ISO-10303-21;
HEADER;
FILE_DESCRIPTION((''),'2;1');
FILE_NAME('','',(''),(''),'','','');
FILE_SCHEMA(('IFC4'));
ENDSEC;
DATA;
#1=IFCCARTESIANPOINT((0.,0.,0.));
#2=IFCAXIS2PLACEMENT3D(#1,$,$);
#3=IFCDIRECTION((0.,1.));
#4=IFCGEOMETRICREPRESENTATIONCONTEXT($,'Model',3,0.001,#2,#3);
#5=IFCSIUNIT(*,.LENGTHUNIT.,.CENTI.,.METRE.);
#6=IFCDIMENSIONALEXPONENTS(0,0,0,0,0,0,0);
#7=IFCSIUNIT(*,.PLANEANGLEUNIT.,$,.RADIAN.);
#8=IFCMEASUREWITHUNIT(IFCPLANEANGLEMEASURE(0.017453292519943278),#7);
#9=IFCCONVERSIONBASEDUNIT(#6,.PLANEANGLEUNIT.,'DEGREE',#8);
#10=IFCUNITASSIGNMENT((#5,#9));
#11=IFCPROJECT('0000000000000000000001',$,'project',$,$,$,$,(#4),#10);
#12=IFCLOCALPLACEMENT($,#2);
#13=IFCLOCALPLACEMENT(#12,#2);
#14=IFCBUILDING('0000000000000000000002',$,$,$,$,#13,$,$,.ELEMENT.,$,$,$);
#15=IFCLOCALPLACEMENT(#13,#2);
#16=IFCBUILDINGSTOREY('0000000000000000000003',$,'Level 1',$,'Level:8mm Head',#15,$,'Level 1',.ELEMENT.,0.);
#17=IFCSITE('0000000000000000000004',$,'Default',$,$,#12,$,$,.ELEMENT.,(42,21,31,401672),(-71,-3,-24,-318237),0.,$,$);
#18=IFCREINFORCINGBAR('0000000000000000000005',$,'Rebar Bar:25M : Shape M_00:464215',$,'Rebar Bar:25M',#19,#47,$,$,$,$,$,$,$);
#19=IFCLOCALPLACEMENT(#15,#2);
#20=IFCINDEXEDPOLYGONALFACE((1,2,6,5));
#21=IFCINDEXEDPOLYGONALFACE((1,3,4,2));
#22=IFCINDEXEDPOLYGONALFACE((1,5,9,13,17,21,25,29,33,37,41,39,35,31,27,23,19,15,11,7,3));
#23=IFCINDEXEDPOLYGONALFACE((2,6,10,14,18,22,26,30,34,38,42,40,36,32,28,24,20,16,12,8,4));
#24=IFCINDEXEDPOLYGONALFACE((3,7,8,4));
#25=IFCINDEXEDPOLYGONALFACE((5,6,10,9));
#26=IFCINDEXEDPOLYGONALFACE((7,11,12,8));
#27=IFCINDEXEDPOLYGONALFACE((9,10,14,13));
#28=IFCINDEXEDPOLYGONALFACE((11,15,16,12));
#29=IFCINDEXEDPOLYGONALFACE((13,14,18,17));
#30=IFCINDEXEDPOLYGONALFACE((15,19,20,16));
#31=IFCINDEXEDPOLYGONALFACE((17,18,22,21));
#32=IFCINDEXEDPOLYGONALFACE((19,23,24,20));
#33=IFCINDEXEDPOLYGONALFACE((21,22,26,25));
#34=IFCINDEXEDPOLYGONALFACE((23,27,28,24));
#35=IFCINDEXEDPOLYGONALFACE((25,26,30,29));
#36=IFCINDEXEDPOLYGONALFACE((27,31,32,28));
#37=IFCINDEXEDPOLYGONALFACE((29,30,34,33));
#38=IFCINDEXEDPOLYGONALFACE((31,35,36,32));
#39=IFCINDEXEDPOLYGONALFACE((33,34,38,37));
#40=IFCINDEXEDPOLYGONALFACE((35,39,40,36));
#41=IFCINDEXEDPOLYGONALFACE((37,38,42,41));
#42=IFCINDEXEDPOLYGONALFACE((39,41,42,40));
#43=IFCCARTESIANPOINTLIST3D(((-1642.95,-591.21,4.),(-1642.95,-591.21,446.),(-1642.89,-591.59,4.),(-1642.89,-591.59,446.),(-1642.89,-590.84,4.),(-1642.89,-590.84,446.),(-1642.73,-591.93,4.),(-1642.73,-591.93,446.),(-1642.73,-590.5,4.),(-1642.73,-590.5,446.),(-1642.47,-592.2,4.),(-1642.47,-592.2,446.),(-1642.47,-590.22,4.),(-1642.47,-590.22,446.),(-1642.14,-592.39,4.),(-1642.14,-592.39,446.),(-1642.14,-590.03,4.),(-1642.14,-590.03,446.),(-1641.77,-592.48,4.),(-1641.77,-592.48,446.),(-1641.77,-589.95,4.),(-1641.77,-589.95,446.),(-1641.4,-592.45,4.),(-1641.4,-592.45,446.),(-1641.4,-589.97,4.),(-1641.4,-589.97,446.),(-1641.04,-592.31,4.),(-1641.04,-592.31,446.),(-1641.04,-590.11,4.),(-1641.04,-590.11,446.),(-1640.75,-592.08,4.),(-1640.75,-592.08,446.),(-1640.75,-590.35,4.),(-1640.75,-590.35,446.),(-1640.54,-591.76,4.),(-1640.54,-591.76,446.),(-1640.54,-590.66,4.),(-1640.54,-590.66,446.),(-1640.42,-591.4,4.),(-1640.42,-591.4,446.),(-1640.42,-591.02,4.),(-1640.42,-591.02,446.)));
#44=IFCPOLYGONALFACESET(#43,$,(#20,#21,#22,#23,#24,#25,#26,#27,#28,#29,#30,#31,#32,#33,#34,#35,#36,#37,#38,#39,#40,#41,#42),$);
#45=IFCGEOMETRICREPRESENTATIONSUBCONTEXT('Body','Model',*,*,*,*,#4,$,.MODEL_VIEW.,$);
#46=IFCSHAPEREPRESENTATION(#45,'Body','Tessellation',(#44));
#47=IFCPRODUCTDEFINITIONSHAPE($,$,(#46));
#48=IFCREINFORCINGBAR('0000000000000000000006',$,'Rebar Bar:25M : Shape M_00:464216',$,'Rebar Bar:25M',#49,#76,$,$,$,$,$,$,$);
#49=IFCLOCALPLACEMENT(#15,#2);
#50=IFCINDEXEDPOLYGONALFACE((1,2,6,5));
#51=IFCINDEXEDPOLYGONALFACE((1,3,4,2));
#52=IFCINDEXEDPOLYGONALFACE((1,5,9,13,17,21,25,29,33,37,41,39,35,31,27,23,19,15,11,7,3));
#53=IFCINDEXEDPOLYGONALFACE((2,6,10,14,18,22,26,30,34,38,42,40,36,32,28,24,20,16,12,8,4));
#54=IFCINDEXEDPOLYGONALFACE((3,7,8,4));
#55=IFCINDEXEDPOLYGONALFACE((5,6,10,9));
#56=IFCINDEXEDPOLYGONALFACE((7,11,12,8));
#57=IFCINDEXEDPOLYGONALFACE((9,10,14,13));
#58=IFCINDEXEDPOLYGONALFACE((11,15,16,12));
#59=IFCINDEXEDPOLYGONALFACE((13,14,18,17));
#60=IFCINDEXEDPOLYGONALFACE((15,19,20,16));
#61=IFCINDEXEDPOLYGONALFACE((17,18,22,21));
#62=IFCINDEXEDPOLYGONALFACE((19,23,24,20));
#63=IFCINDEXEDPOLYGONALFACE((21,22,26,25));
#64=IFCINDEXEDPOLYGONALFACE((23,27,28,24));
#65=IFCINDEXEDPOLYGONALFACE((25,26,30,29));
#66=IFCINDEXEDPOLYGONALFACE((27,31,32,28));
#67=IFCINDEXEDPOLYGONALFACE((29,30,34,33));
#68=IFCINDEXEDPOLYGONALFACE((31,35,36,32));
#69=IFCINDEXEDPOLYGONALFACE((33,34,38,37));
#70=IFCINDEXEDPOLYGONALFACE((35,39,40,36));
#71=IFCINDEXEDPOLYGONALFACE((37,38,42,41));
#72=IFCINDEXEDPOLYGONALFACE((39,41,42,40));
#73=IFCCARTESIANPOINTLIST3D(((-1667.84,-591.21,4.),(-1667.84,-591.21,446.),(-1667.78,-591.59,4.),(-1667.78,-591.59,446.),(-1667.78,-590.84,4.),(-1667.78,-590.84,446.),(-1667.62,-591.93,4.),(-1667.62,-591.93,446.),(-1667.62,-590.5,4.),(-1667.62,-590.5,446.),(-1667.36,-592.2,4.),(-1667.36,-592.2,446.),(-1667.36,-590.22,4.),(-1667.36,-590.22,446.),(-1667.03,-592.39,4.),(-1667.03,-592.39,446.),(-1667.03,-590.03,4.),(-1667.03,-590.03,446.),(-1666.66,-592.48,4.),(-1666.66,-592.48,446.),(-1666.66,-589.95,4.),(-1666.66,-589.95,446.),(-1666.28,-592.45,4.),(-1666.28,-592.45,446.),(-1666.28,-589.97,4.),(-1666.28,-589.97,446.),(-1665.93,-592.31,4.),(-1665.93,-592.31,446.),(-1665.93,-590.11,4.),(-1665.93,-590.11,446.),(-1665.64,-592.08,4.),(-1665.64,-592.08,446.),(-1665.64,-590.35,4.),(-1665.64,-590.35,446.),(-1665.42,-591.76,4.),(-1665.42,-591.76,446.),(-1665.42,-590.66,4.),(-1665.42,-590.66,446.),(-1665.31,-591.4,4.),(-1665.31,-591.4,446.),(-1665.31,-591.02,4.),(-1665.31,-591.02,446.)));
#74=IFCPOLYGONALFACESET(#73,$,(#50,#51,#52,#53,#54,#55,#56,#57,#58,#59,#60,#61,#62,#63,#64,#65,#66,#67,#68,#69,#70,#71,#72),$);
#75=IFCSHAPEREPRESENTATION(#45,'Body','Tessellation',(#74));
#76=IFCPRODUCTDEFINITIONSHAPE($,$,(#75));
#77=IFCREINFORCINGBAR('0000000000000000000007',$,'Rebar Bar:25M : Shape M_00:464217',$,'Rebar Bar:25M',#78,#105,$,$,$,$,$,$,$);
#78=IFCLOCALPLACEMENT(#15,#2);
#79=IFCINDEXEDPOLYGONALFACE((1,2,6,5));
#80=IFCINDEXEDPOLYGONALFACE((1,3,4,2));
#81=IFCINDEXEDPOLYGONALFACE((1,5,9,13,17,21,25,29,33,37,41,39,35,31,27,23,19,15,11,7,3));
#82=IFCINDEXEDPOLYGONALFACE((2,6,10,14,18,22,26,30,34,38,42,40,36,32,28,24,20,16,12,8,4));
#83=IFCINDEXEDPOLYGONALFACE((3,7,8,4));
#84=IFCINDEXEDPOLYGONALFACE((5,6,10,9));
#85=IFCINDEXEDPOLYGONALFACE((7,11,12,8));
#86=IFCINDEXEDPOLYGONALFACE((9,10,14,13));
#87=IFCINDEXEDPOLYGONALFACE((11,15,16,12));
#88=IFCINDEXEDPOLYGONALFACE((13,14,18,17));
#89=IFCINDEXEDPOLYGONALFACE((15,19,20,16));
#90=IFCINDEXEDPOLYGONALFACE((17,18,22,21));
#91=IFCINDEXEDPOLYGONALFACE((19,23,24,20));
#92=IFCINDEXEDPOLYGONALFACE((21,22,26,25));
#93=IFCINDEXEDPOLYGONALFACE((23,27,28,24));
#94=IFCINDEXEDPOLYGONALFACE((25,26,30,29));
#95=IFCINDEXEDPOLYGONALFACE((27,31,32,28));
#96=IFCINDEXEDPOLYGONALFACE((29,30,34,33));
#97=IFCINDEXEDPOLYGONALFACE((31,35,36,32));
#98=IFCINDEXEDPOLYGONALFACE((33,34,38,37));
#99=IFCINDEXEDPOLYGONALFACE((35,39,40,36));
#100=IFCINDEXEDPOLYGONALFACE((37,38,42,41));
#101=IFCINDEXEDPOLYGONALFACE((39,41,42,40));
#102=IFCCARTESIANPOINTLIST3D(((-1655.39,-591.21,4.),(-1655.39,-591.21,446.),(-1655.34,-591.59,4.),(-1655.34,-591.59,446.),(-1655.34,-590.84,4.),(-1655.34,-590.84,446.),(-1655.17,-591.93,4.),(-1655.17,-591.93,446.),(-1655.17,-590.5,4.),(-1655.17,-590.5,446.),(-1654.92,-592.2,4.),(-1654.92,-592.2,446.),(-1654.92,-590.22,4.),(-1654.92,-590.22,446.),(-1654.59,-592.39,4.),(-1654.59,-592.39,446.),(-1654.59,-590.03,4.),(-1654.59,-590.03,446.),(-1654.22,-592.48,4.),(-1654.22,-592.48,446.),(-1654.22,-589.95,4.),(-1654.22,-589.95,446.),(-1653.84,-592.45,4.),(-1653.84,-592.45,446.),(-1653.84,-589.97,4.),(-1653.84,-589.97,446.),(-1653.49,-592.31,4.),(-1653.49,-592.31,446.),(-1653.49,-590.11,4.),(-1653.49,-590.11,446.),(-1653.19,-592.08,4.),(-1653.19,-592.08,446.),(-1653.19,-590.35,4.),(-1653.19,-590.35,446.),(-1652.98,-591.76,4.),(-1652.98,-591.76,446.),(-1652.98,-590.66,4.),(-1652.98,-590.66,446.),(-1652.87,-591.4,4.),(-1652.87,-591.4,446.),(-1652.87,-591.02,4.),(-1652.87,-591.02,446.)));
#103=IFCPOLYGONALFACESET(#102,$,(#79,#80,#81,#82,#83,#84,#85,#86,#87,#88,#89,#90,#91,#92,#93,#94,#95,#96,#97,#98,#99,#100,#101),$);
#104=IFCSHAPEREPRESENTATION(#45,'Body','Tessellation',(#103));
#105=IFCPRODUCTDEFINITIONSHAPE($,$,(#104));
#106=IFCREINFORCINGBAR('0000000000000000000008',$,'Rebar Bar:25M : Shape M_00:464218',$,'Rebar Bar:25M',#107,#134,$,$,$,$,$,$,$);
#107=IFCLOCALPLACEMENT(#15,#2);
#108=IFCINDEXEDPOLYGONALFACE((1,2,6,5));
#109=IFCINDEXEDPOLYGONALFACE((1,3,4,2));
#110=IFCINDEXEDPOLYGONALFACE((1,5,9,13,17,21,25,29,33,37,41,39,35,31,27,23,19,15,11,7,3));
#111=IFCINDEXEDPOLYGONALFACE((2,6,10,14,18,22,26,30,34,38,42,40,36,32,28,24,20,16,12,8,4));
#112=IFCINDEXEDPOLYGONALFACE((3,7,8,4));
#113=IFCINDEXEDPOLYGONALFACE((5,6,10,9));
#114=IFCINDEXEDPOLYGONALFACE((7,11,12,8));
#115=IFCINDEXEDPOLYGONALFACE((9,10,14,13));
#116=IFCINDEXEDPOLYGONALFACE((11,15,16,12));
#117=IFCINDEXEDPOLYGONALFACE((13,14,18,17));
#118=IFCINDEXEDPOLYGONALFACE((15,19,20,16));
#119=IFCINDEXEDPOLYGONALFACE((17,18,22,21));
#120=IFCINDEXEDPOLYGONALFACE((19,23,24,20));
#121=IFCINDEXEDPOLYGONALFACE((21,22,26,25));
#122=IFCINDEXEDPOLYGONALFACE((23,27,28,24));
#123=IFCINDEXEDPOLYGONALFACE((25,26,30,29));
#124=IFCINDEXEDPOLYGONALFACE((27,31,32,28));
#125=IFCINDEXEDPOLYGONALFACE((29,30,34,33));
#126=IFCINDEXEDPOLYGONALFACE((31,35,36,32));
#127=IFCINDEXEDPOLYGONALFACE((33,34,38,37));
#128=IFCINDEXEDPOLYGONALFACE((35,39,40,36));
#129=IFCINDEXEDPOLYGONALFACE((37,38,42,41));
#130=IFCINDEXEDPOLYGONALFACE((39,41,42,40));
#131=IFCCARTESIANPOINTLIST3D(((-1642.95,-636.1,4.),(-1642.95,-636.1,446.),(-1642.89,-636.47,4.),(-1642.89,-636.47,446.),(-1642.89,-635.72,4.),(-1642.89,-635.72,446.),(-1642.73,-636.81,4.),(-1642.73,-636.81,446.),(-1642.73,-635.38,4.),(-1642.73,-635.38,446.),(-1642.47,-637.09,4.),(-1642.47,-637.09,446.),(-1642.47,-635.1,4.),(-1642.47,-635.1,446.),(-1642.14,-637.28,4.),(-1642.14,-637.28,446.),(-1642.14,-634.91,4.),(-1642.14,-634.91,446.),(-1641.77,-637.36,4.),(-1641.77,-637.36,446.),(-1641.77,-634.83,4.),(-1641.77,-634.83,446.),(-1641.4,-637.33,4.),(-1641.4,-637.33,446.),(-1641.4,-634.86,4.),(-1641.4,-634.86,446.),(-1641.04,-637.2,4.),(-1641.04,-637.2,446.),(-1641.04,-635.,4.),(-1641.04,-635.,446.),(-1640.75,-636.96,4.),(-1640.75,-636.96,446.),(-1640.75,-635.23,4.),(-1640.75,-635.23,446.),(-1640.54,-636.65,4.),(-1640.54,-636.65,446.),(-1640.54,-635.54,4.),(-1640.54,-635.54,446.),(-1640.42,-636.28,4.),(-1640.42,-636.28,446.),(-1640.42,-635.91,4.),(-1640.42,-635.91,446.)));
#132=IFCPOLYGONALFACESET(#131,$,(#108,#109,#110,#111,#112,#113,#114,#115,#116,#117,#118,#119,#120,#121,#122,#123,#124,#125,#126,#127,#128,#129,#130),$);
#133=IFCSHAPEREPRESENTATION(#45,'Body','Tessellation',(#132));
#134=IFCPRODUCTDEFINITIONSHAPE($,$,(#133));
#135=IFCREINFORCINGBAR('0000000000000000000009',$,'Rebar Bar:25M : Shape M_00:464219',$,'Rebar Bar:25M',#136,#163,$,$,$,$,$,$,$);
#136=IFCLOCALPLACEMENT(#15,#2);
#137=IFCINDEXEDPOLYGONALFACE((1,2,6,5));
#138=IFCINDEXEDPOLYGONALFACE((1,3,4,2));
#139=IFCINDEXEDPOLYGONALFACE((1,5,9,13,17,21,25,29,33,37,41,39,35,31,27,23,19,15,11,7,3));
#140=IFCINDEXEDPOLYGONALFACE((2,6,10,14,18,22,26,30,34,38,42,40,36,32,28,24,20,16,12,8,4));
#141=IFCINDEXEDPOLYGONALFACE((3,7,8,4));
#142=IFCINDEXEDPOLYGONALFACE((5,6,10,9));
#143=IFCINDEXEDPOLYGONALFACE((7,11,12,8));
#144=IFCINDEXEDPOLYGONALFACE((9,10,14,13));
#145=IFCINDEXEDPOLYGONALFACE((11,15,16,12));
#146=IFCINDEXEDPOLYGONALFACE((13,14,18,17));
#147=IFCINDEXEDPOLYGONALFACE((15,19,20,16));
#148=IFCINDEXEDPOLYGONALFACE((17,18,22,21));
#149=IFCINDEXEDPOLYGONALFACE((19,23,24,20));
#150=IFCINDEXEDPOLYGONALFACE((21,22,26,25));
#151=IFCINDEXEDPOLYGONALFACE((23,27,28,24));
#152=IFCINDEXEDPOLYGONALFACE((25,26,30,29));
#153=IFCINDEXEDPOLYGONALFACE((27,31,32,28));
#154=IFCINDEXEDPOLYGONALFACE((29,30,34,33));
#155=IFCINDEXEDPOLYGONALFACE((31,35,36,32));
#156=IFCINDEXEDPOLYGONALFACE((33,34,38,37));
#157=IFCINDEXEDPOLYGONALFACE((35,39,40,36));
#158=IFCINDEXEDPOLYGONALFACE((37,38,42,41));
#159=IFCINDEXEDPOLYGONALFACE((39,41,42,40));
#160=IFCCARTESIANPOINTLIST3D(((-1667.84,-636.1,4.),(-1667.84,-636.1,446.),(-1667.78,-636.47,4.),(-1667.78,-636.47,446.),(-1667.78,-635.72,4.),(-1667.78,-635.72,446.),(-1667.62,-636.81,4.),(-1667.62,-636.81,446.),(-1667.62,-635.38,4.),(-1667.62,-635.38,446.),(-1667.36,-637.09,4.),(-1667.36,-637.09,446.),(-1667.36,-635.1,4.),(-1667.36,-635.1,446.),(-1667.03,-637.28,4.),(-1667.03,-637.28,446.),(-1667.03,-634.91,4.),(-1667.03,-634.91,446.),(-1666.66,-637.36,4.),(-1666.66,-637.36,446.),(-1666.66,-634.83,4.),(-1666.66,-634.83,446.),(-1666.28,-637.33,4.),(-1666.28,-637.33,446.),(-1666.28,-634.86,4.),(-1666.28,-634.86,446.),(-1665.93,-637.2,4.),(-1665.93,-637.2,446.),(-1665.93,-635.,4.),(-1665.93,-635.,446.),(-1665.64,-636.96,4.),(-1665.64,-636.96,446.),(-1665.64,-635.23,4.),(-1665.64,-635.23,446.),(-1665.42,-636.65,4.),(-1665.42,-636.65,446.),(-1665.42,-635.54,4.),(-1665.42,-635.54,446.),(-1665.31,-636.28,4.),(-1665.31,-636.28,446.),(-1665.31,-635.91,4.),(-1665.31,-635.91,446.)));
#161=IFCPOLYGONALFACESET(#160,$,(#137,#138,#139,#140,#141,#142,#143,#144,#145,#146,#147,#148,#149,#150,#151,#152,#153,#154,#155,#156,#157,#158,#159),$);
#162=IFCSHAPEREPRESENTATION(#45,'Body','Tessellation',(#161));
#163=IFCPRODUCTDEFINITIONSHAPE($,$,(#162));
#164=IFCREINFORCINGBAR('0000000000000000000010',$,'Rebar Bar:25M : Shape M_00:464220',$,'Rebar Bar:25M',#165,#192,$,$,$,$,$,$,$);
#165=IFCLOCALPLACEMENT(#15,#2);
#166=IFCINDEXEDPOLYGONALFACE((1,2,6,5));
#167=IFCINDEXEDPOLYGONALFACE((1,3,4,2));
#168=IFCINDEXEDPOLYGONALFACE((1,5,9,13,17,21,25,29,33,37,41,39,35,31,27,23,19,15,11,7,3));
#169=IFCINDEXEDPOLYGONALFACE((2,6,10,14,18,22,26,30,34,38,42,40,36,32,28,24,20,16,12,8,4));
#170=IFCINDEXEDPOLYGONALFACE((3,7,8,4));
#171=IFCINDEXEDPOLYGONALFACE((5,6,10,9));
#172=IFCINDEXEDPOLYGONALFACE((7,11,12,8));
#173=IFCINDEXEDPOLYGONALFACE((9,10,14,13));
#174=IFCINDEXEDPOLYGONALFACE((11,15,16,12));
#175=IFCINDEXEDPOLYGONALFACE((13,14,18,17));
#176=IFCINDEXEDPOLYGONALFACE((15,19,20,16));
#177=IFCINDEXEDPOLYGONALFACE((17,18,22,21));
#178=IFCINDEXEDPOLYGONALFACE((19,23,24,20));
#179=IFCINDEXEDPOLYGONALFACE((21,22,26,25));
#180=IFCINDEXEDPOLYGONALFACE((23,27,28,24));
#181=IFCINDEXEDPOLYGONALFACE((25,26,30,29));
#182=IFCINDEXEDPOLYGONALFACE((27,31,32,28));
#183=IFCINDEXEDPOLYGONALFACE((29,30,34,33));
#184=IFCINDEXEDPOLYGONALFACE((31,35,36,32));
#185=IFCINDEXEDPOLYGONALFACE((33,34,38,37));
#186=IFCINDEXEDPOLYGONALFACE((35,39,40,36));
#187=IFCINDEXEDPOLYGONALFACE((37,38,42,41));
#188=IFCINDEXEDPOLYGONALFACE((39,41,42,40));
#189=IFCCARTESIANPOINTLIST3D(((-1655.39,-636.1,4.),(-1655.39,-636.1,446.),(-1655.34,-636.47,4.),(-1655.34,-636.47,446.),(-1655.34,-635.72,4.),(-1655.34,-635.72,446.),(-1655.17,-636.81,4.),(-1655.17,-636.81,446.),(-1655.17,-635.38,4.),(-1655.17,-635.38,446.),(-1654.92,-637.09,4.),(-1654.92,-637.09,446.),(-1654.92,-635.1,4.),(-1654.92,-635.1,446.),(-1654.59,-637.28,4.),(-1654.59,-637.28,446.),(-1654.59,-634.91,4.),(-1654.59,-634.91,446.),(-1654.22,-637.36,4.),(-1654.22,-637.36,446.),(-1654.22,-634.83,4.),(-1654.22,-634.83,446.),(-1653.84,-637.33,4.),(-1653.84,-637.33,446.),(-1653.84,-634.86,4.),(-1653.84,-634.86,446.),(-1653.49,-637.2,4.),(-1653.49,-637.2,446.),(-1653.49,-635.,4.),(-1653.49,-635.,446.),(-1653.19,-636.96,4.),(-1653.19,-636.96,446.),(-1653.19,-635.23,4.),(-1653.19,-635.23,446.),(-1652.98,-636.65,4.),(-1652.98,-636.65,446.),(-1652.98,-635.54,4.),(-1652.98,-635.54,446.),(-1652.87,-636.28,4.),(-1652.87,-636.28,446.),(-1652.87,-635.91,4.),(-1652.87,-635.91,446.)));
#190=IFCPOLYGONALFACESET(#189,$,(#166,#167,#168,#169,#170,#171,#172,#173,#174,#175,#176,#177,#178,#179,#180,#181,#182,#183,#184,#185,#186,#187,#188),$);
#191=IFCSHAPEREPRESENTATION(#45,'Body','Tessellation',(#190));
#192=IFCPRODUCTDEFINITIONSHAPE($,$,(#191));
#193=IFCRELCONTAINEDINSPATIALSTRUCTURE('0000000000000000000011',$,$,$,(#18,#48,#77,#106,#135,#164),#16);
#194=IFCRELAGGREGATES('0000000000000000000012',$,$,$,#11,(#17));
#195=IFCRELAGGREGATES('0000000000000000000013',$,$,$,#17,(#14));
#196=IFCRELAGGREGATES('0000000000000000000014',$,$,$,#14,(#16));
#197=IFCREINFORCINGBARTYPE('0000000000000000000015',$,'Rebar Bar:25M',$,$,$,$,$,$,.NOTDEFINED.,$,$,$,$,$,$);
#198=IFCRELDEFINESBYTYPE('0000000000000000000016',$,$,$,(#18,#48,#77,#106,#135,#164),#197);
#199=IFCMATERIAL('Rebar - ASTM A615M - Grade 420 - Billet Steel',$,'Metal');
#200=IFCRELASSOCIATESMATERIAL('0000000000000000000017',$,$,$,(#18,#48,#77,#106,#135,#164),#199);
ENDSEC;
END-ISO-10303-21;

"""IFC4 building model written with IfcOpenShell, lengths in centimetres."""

from ifc_helpers import new_model, entity, si_unit, converted_unit, direction, origin, place, context, subcontext, project, spatial, material, type_object, element, save


model = new_model("IFC4")

# Units and contexts
model_context = context("Model", 3, precision=0.001, world=origin(), true_north=direction((0.0, 1.0)))
body_context = subcontext(model_context, "Body", "Model", "MODEL_VIEW")
ifc_project = project(units=[si_unit("LENGTHUNIT", "METRE", prefix="CENTI"), converted_unit("PLANEANGLEUNIT", "DEGREE", entity("IfcPlaneAngleMeasure", 0.017453292519943278), si_unit("PLANEANGLEUNIT", "RADIAN"), dimensions=[0, 0, 0, 0, 0, 0, 0])], contexts=[model_context])

# Site, building, storey
site_placement = place(None, origin())
site = spatial("IfcSite", under=ifc_project, at=site_placement, Name="Default", CompositionType="ELEMENT", RefLatitude=(42, 21, 31, 401672), RefLongitude=(-71, -3, -24, -318237), RefElevation=0.0)
building_placement = place(site_placement, origin())
building = spatial("IfcBuilding", under=site, at=building_placement, CompositionType="ELEMENT")
storey_placement = place(building_placement, origin())
storey = spatial("IfcBuildingStorey", under=building, at=storey_placement, Name="Level 1", ObjectType="Level:8mm Head", LongName="Level 1", CompositionType="ELEMENT", Elevation=0.0)

# Reinforcing bars
ifc_material = material(Name="Rebar - ASTM A615M - Grade 420 - Billet Steel", Category="Metal")
reinforcing_bar_type_1 = type_object("IfcReinforcingBarType", Name="Rebar Bar:25M", PredefinedType="NOTDEFINED")
reinforcing_bar_1_placement = place(storey_placement, origin())
element("IfcReinforcingBar", 1, at=reinforcing_bar_1_placement, inside=storey, type_object=reinforcing_bar_type_1, material=ifc_material, Name="Rebar Bar:25M : Shape M_00:464215", ObjectType="Rebar Bar:25M", context=body_context, shape_type="AdvancedSweptSolid", body=[
    entity("IfcSweptDiskSolid", entity("IfcIndexedPolyCurve", entity("IfcCartesianPointList3D", [[-1641.68, -591.21, 446.0], [-1641.68, -591.21, 4.0]]), None, False), 1.27, None, 0.0, 1.0),
])
reinforcing_bar_2_placement = place(storey_placement, origin())
element("IfcReinforcingBar", 2, at=reinforcing_bar_2_placement, inside=storey, type_object=reinforcing_bar_type_1, material=ifc_material, Name="Rebar Bar:25M : Shape M_00:464216", ObjectType="Rebar Bar:25M", context=body_context, shape_type="AdvancedSweptSolid", body=[
    entity("IfcSweptDiskSolid", entity("IfcIndexedPolyCurve", entity("IfcCartesianPointList3D", [[-1666.57, -591.21, 446.0], [-1666.57, -591.21, 4.0]]), None, False), 1.27, None, 0.0, 1.0),
])
reinforcing_bar_3_placement = place(storey_placement, origin())
element("IfcReinforcingBar", 3, at=reinforcing_bar_3_placement, inside=storey, type_object=reinforcing_bar_type_1, material=ifc_material, Name="Rebar Bar:25M : Shape M_00:464217", ObjectType="Rebar Bar:25M", context=body_context, shape_type="AdvancedSweptSolid", body=[
    entity("IfcSweptDiskSolid", entity("IfcIndexedPolyCurve", entity("IfcCartesianPointList3D", [[-1654.12, -591.21, 446.0], [-1654.12, -591.21, 4.0]]), None, False), 1.27, None, 0.0, 1.0),
])
reinforcing_bar_4_placement = place(storey_placement, origin())
element("IfcReinforcingBar", 4, at=reinforcing_bar_4_placement, inside=storey, type_object=reinforcing_bar_type_1, material=ifc_material, Name="Rebar Bar:25M : Shape M_00:464218", ObjectType="Rebar Bar:25M", context=body_context, shape_type="AdvancedSweptSolid", body=[
    entity("IfcSweptDiskSolid", entity("IfcIndexedPolyCurve", entity("IfcCartesianPointList3D", [[-1641.68, -636.1, 446.0], [-1641.68, -636.1, 4.0]]), None, False), 1.27, None, 0.0, 1.0),
])
reinforcing_bar_5_placement = place(storey_placement, origin())
element("IfcReinforcingBar", 5, at=reinforcing_bar_5_placement, inside=storey, type_object=reinforcing_bar_type_1, material=ifc_material, Name="Rebar Bar:25M : Shape M_00:464219", ObjectType="Rebar Bar:25M", context=body_context, shape_type="AdvancedSweptSolid", body=[
    entity("IfcSweptDiskSolid", entity("IfcIndexedPolyCurve", entity("IfcCartesianPointList3D", [[-1666.57, -636.1, 446.0], [-1666.57, -636.1, 4.0]]), None, False), 1.27, None, 0.0, 1.0),
])
reinforcing_bar_6_placement = place(storey_placement, origin())
element("IfcReinforcingBar", 6, at=reinforcing_bar_6_placement, inside=storey, type_object=reinforcing_bar_type_1, material=ifc_material, Name="Rebar Bar:25M : Shape M_00:464220", ObjectType="Rebar Bar:25M", context=body_context, shape_type="AdvancedSweptSolid", body=[
    entity("IfcSweptDiskSolid", entity("IfcIndexedPolyCurve", entity("IfcCartesianPointList3D", [[-1654.12, -636.1, 446.0], [-1654.12, -636.1, 4.0]]), None, False), 1.27, None, 0.0, 1.0),
])

save(model, "model.ifc")
